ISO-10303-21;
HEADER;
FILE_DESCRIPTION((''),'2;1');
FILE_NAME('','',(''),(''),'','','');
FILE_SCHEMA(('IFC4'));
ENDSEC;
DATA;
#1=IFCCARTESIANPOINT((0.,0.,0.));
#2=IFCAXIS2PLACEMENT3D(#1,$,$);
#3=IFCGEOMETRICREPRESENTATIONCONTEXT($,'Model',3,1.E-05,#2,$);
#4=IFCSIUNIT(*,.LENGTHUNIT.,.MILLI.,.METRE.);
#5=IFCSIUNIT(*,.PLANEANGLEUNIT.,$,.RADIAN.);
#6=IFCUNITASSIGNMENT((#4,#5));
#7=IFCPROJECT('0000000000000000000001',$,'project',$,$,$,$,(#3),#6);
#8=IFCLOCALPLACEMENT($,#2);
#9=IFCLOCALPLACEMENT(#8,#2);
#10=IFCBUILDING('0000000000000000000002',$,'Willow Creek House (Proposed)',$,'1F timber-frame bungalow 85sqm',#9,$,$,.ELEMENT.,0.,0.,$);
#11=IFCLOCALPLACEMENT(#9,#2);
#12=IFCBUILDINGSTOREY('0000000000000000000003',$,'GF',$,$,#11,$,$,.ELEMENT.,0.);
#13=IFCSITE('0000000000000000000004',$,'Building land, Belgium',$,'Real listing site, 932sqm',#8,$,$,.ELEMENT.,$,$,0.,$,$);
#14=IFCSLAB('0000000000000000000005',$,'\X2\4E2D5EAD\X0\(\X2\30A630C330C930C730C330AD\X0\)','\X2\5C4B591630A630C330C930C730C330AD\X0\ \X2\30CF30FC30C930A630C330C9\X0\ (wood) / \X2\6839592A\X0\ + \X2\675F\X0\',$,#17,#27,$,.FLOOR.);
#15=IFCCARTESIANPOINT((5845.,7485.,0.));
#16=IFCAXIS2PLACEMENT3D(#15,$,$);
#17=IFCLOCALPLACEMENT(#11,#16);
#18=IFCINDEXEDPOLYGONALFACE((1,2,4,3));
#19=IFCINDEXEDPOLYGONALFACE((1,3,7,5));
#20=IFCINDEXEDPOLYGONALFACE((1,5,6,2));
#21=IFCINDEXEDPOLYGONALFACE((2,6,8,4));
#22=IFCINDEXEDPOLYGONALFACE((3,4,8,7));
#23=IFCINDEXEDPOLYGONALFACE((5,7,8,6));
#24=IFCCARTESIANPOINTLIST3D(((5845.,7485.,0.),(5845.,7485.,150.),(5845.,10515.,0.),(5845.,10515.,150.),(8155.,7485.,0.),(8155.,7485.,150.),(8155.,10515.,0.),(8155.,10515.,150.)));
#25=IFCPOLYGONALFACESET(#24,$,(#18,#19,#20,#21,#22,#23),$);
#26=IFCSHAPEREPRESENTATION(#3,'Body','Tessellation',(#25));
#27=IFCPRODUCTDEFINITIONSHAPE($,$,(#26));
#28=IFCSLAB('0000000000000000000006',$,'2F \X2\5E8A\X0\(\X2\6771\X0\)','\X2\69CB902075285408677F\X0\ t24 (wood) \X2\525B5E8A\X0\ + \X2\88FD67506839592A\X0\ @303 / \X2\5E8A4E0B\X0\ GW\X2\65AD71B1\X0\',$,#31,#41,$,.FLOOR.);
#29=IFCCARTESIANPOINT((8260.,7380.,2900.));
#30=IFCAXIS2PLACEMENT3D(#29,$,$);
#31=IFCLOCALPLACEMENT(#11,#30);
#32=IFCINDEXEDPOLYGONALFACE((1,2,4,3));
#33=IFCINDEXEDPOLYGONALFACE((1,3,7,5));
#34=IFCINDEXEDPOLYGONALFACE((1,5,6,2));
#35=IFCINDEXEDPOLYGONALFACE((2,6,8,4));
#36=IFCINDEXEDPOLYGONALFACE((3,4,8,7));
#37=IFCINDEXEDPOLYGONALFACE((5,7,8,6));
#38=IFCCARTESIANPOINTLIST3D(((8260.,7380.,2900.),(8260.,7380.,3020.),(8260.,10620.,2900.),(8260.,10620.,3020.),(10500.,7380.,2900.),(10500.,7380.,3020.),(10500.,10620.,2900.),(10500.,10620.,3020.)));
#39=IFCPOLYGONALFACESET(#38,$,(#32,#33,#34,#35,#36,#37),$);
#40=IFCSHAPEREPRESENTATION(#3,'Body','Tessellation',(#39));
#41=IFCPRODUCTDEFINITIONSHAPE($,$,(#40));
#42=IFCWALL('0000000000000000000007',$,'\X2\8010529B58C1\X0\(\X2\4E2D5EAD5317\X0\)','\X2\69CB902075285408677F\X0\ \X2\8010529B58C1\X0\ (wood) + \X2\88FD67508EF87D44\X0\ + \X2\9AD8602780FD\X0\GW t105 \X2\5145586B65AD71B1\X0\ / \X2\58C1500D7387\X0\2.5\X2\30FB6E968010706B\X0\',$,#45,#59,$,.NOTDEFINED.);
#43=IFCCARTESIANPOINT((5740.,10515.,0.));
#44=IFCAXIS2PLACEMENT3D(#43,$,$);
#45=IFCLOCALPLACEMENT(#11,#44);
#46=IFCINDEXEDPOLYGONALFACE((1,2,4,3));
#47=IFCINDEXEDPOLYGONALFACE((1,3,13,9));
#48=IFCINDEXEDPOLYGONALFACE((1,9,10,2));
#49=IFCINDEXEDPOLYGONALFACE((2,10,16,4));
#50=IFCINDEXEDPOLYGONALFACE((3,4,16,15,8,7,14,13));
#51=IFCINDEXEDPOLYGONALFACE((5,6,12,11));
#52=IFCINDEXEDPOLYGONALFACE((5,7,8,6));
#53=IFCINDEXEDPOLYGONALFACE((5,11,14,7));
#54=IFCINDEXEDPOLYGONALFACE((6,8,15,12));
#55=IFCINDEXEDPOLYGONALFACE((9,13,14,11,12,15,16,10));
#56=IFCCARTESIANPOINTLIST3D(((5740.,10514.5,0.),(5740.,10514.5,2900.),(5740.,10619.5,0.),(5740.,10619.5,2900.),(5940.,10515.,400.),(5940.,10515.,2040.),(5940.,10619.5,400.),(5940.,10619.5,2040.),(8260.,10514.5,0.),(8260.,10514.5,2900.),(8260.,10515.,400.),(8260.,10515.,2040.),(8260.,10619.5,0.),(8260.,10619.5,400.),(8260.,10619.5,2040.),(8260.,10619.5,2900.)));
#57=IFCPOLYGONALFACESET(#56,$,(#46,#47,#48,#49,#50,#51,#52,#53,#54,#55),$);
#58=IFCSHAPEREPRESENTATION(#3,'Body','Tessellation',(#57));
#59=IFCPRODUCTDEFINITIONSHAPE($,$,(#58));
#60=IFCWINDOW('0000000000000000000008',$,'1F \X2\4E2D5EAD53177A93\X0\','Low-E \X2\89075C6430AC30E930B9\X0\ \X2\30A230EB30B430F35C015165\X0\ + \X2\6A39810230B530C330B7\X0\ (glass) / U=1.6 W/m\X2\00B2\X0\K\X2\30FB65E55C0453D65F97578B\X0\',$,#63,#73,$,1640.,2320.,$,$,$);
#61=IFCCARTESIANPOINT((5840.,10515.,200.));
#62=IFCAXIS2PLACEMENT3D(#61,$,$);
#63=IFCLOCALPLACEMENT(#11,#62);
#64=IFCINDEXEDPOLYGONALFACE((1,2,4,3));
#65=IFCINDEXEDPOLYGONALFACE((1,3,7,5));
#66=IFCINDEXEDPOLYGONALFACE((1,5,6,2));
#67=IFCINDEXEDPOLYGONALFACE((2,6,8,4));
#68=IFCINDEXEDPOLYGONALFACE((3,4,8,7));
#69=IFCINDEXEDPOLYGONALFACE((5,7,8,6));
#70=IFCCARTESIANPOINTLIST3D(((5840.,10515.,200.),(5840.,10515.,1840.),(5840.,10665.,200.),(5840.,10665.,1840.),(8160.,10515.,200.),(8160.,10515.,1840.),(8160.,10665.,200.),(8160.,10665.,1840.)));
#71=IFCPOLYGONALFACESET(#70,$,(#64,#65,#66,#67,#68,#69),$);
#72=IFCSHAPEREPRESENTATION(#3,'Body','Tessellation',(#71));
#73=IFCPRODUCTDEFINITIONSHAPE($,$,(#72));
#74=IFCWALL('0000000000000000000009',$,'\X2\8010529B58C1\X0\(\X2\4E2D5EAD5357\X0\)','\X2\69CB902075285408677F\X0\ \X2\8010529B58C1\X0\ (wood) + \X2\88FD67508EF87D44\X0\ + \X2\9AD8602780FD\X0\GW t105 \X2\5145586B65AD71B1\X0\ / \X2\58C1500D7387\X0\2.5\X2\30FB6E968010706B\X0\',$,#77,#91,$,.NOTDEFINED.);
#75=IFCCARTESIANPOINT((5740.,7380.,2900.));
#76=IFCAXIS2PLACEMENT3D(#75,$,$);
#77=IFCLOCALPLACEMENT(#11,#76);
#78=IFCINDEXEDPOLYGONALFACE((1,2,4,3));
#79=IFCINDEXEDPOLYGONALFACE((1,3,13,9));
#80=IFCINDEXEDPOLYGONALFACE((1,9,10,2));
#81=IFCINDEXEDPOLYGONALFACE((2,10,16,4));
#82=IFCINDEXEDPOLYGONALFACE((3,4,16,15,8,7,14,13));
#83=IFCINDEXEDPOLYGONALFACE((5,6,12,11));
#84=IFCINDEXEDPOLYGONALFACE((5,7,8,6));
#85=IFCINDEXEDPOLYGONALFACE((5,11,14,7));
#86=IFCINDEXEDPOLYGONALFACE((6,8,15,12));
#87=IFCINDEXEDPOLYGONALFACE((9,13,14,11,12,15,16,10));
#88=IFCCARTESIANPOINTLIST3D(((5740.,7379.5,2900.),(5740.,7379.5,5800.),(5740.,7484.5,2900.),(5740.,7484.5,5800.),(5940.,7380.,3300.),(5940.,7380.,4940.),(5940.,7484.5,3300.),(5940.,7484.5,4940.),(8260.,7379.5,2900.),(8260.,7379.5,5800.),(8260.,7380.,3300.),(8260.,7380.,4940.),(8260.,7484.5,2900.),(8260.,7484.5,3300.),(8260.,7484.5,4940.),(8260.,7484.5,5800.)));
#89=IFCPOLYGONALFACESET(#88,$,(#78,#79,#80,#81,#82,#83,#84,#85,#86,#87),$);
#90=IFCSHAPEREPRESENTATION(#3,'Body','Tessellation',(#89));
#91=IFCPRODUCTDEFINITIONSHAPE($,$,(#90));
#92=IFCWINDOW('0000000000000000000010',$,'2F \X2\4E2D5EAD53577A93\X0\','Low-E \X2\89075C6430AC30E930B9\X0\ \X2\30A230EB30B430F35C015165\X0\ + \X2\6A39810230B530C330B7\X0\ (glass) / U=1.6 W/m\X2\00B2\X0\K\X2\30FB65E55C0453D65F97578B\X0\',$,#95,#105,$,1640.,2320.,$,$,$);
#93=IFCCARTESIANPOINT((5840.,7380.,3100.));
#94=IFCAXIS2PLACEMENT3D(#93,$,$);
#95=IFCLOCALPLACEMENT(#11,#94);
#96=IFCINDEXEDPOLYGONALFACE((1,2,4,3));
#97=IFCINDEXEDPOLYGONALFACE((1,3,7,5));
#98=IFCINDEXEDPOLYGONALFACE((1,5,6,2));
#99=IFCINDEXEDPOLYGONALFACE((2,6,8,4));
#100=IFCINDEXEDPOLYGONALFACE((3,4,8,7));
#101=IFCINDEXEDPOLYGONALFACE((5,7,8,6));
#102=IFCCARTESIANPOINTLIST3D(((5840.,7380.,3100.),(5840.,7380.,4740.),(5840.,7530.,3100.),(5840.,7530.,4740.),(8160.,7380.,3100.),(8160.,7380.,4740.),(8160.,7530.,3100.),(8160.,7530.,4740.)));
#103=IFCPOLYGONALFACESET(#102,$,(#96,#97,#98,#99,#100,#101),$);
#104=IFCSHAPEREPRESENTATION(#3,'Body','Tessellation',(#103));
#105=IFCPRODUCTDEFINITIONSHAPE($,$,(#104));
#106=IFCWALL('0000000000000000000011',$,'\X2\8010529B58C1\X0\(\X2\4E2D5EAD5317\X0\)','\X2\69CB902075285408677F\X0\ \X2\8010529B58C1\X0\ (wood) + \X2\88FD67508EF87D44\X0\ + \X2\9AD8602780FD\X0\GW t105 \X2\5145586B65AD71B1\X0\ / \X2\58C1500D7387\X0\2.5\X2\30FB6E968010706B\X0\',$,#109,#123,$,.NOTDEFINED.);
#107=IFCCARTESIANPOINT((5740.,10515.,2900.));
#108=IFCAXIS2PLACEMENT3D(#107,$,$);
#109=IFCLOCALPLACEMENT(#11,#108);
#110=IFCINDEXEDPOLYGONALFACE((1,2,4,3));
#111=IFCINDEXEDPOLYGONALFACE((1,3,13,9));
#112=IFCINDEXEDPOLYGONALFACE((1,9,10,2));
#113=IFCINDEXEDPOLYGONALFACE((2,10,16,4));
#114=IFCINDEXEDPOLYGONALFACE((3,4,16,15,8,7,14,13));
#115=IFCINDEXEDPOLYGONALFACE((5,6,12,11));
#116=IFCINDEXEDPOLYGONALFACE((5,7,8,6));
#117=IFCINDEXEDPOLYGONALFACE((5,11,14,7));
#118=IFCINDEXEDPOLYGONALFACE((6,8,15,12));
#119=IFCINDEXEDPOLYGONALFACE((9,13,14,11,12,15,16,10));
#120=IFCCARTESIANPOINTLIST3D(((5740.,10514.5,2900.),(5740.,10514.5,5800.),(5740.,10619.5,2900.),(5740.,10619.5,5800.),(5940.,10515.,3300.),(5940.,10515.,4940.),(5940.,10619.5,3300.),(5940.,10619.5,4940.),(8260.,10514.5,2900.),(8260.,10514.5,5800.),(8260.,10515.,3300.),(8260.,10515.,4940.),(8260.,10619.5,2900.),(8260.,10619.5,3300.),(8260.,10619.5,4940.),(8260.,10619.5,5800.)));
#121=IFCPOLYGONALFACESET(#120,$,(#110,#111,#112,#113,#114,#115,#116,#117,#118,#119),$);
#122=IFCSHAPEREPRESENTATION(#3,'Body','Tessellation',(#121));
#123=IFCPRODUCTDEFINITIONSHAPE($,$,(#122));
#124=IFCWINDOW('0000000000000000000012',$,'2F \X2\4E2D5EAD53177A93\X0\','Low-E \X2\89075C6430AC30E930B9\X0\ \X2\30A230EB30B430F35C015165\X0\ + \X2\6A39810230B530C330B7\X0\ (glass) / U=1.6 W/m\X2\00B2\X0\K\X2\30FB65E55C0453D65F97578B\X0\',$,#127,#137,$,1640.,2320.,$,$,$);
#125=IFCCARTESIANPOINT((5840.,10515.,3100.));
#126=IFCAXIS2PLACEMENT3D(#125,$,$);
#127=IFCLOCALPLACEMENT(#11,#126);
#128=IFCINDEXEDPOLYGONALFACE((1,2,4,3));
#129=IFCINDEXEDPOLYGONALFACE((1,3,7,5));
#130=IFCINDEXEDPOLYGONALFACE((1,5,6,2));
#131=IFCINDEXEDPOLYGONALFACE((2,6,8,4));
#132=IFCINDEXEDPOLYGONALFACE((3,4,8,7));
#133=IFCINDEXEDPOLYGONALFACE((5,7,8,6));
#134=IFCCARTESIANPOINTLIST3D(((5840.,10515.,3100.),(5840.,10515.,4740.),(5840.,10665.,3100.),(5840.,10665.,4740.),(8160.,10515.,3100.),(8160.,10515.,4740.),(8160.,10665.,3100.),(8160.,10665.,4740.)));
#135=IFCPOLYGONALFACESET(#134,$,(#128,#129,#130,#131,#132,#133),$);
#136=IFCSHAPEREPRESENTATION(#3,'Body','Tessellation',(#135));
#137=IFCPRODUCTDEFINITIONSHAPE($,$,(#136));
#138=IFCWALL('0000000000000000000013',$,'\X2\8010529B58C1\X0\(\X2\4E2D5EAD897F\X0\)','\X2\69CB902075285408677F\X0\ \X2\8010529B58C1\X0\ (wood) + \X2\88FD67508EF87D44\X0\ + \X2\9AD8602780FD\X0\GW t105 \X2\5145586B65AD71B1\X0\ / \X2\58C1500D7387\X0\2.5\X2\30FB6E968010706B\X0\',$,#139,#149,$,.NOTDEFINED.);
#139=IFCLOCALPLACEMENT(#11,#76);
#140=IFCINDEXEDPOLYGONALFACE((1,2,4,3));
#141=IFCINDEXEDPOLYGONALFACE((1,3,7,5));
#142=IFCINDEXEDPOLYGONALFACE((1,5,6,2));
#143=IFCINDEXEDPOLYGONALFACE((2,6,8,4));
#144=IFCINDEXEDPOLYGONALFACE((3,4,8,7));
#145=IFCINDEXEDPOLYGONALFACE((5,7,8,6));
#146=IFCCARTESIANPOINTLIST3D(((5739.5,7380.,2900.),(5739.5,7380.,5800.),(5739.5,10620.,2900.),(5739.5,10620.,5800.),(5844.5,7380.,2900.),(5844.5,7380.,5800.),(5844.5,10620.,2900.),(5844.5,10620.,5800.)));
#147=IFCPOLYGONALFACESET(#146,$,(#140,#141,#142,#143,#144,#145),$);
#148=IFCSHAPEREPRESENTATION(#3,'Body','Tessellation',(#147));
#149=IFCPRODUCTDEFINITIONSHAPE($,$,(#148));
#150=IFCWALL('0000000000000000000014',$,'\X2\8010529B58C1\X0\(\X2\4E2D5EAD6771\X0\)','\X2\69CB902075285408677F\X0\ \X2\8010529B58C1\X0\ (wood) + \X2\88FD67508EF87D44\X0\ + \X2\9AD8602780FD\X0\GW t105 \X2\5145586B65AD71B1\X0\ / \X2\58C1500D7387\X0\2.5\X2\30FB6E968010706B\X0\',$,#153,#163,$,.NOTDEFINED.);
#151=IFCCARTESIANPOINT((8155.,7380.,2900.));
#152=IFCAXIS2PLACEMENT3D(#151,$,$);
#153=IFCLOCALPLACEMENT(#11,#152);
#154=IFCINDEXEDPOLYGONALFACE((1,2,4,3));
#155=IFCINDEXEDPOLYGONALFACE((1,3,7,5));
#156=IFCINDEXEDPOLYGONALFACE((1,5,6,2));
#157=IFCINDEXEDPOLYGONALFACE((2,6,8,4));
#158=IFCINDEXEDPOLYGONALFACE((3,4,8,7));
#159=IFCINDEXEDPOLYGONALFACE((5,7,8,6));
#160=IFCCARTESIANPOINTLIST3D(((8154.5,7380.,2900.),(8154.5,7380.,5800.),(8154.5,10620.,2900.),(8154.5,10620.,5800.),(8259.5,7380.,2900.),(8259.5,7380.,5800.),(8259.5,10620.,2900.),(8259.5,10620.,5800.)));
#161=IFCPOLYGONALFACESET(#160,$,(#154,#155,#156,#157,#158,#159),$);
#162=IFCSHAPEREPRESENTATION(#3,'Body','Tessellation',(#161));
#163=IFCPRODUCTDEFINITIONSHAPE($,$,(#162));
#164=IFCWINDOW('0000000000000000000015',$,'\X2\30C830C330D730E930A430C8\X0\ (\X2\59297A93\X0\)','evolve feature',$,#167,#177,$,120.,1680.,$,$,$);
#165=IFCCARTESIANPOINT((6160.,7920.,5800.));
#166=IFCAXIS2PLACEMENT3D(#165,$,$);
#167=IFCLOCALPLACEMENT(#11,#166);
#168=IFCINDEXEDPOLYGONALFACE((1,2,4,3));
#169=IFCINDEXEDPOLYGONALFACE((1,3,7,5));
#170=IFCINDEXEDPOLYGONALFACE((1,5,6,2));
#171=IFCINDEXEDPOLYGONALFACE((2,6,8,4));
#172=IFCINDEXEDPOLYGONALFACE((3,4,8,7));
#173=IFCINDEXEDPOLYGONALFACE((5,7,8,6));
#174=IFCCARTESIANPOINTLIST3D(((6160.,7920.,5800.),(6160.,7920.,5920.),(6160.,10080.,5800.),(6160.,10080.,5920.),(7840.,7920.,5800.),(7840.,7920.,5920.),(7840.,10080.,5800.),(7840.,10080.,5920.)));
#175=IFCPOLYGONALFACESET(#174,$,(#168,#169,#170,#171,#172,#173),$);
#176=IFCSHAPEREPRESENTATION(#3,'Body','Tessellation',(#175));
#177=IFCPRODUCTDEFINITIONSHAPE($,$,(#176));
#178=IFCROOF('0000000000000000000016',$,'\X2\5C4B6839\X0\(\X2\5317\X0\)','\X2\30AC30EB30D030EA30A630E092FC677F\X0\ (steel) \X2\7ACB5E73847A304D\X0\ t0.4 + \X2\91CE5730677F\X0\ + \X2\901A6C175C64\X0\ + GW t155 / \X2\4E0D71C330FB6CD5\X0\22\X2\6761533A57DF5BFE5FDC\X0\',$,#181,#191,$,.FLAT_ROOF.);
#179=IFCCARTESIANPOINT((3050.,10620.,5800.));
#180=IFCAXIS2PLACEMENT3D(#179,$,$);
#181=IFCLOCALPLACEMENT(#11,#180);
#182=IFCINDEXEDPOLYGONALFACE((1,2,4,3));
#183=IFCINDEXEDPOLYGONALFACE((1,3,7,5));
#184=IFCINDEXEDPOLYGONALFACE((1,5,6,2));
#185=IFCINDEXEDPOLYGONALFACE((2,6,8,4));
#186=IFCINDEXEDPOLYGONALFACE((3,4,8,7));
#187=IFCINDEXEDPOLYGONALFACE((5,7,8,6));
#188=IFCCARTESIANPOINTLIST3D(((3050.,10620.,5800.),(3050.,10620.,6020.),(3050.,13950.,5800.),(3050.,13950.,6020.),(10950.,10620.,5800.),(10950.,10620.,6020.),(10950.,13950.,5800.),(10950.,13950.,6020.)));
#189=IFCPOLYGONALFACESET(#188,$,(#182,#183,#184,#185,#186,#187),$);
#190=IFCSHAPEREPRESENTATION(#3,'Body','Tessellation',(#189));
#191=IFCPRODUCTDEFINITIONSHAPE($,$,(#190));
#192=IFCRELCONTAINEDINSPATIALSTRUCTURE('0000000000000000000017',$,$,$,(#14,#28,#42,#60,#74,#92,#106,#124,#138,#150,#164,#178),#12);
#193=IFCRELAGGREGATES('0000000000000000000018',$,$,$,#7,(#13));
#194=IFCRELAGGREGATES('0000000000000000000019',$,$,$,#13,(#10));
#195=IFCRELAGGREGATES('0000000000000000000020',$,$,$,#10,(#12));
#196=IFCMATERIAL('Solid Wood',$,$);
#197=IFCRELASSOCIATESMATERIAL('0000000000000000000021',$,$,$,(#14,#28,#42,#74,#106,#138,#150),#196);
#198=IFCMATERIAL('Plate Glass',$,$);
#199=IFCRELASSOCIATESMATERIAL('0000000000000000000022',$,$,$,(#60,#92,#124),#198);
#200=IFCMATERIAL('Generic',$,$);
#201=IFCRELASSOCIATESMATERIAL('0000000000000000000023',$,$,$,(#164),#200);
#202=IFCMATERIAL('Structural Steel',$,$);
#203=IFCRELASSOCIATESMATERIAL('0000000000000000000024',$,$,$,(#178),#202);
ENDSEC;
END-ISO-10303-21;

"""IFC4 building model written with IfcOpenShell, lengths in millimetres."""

from ifc_helpers import new_model, si_unit, frame, frame_2d, origin, place, context, project, spatial, rectangle, extrude, material, element, fill, save


model = new_model("IFC4")

# Units and contexts
model_context = context("Model", 3, precision=1e-05, world=origin())
ifc_project = project(units=[si_unit("LENGTHUNIT", "METRE", prefix="MILLI"), si_unit("PLANEANGLEUNIT", "RADIAN")], contexts=[model_context])

# Site, building, storey
site_placement = place(None, origin())
site = spatial("IfcSite", under=ifc_project, at=site_placement, Name="Building land, Belgium", ObjectType="Real listing site, 932sqm", CompositionType="ELEMENT", RefElevation=0.0)
building_placement = place(site_placement, origin())
building = spatial("IfcBuilding", under=site, at=building_placement, Name="Willow Creek House (Proposed)", ObjectType="1F timber-frame bungalow 85sqm", CompositionType="ELEMENT", ElevationOfRefHeight=0.0, ElevationOfTerrain=0.0)
storey_placement = place(building_placement, origin())
storey = spatial("IfcBuildingStorey", under=building, at=storey_placement, Name="GF", CompositionType="ELEMENT", Elevation=0.0)

# Slabs
ifc_material_1 = material(Name="Solid Wood")
slab_1_placement = place(storey_placement, frame((5845.0, 7485.0, 0.0)))
element("IfcSlab", 1, at=slab_1_placement, inside=storey, material=ifc_material_1, Name="中庭(ウッドデッキ)", Description="屋外ウッドデッキ ハードウッド (wood) / 根太 + 束", PredefinedType="FLOOR", context=model_context, shape_type="SweptSolid", body=[
    extrude(rectangle(XDim=2310.0, YDim=3030.0, at=frame_2d((1155.0, 1515.0))), frame((5845.0, 7485.0, 0.0)), (0.0, 0.0, 1.0), 150.0),
])
slab_2_placement = place(storey_placement, frame((8260.0, 7380.0, 2900.0)))
element("IfcSlab", 2, at=slab_2_placement, inside=storey, material=ifc_material_1, Name="2F 床(東)", Description="構造用合板 t24 (wood) 剛床 + 製材根太 @303 / 床下 GW断熱", PredefinedType="FLOOR", context=model_context, shape_type="SweptSolid", body=[
    extrude(rectangle(XDim=2240.0, YDim=3240.0, at=frame_2d((1120.0, 1620.0))), frame((8260.0, 7380.0, 2900.0)), (0.0, 0.0, 1.0), 120.0),
])

# Walls, openings, windows
wall_1_placement = place(storey_placement, frame((5740.0, 10515.0, 0.0)))
wall_1 = element("IfcWall", 3, at=wall_1_placement, inside=storey, material=ifc_material_1, Name="耐力壁(中庭北)", Description="構造用合板 耐力壁 (wood) + 製材軸組 + 高性能GW t105 充填断熱 / 壁倍率2.5・準耐火", PredefinedType="NOTDEFINED", context=model_context, shape_type="SweptSolid", body=[
    extrude(rectangle(XDim=2520.0, YDim=105.0, at=frame_2d((1260.0, 52.0))), frame((5740.0, 10515.0, 0.0)), (0.0, 0.0, 1.0), 2900.0),
])
opening_1_placement = place(storey_placement, frame((5840.0, 10515.0, 200.0)))
opening_1 = element("IfcOpeningElement", 4, at=opening_1_placement, cuts=wall_1, PredefinedType="NOTDEFINED", context=model_context, shape_type="SweptSolid", body=[
    extrude(rectangle(XDim=2320.0, YDim=150.0, at=frame_2d((1160.0, 75.0))), frame((5840.0, 10515.0, 200.0)), (0.0, 0.0, 1.0), 1640.0),
])
ifc_material_2 = material(Name="Plate Glass")
window_1_placement = place(storey_placement, frame((5840.0, 10515.0, 200.0)))
window_1 = element("IfcWindow", 5, at=window_1_placement, inside=storey, material=ifc_material_2, Name="1F 中庭北窓", Description="Low-E 複層ガラス アルゴン封入 + 樹脂サッシ (glass) / U=1.6 W/m²K・日射取得型", OverallHeight=1640.0, OverallWidth=2320.0, context=model_context, shape_type="SweptSolid", body=[
    extrude(rectangle(XDim=2320.0, YDim=150.0, at=frame_2d((1160.0, 75.0))), frame((5840.0, 10515.0, 200.0)), (0.0, 0.0, 1.0), 1640.0),
])
fill(opening_1, window_1)
wall_2_placement = place(storey_placement, frame((5740.0, 7380.0, 2900.0)))
wall_2 = element("IfcWall", 6, at=wall_2_placement, inside=storey, material=ifc_material_1, Name="耐力壁(中庭南)", Description="構造用合板 耐力壁 (wood) + 製材軸組 + 高性能GW t105 充填断熱 / 壁倍率2.5・準耐火", PredefinedType="NOTDEFINED", context=model_context, shape_type="SweptSolid", body=[
    extrude(rectangle(XDim=2520.0, YDim=105.0, at=frame_2d((1260.0, 52.0))), frame((5740.0, 7380.0, 2900.0)), (0.0, 0.0, 1.0), 2900.0),
])
opening_2_placement = place(storey_placement, frame((5840.0, 7380.0, 3100.0)))
opening_2 = element("IfcOpeningElement", 7, at=opening_2_placement, cuts=wall_2, PredefinedType="NOTDEFINED", context=model_context, shape_type="SweptSolid", body=[
    extrude(rectangle(XDim=2320.0, YDim=150.0, at=frame_2d((1160.0, 75.0))), frame((5840.0, 7380.0, 3100.0)), (0.0, 0.0, 1.0), 1640.0),
])
window_2_placement = place(storey_placement, frame((5840.0, 7380.0, 3100.0)))
window_2 = element("IfcWindow", 8, at=window_2_placement, inside=storey, material=ifc_material_2, Name="2F 中庭南窓", Description="Low-E 複層ガラス アルゴン封入 + 樹脂サッシ (glass) / U=1.6 W/m²K・日射取得型", OverallHeight=1640.0, OverallWidth=2320.0, context=model_context, shape_type="SweptSolid", body=[
    extrude(rectangle(XDim=2320.0, YDim=150.0, at=frame_2d((1160.0, 75.0))), frame((5840.0, 7380.0, 3100.0)), (0.0, 0.0, 1.0), 1640.0),
])
fill(opening_2, window_2)
wall_3_placement = place(storey_placement, frame((5740.0, 10515.0, 2900.0)))
wall_3 = element("IfcWall", 9, at=wall_3_placement, inside=storey, material=ifc_material_1, Name="耐力壁(中庭北)", Description="構造用合板 耐力壁 (wood) + 製材軸組 + 高性能GW t105 充填断熱 / 壁倍率2.5・準耐火", PredefinedType="NOTDEFINED", context=model_context, shape_type="SweptSolid", body=[
    extrude(rectangle(XDim=2520.0, YDim=105.0, at=frame_2d((1260.0, 52.0))), frame((5740.0, 10515.0, 2900.0)), (0.0, 0.0, 1.0), 2900.0),
])
opening_3_placement = place(storey_placement, frame((5840.0, 10515.0, 3100.0)))
opening_3 = element("IfcOpeningElement", 10, at=opening_3_placement, cuts=wall_3, PredefinedType="NOTDEFINED", context=model_context, shape_type="SweptSolid", body=[
    extrude(rectangle(XDim=2320.0, YDim=150.0, at=frame_2d((1160.0, 75.0))), frame((5840.0, 10515.0, 3100.0)), (0.0, 0.0, 1.0), 1640.0),
])
window_3_placement = place(storey_placement, frame((5840.0, 10515.0, 3100.0)))
window_3 = element("IfcWindow", 11, at=window_3_placement, inside=storey, material=ifc_material_2, Name="2F 中庭北窓", Description="Low-E 複層ガラス アルゴン封入 + 樹脂サッシ (glass) / U=1.6 W/m²K・日射取得型", OverallHeight=1640.0, OverallWidth=2320.0, context=model_context, shape_type="SweptSolid", body=[
    extrude(rectangle(XDim=2320.0, YDim=150.0, at=frame_2d((1160.0, 75.0))), frame((5840.0, 10515.0, 3100.0)), (0.0, 0.0, 1.0), 1640.0),
])
fill(opening_3, window_3)

# Walls
wall_4_placement = place(storey_placement, frame((5740.0, 7380.0, 2900.0)))
element("IfcWall", 12, at=wall_4_placement, inside=storey, material=ifc_material_1, Name="耐力壁(中庭西)", Description="構造用合板 耐力壁 (wood) + 製材軸組 + 高性能GW t105 充填断熱 / 壁倍率2.5・準耐火", PredefinedType="NOTDEFINED", context=model_context, shape_type="SweptSolid", body=[
    extrude(rectangle(XDim=105.0, YDim=3240.0, at=frame_2d((52.0, 1620.0))), frame((5740.0, 7380.0, 2900.0)), (0.0, 0.0, 1.0), 2900.0),
])
wall_5_placement = place(storey_placement, frame((8155.0, 7380.0, 2900.0)))
element("IfcWall", 13, at=wall_5_placement, inside=storey, material=ifc_material_1, Name="耐力壁(中庭東)", Description="構造用合板 耐力壁 (wood) + 製材軸組 + 高性能GW t105 充填断熱 / 壁倍率2.5・準耐火", PredefinedType="NOTDEFINED", context=model_context, shape_type="SweptSolid", body=[
    extrude(rectangle(XDim=105.0, YDim=3240.0, at=frame_2d((52.0, 1620.0))), frame((8155.0, 7380.0, 2900.0)), (0.0, 0.0, 1.0), 2900.0),
])

# Window
ifc_material_3 = material(Name="Generic")
window_4_placement = place(storey_placement, frame((6160.0, 7920.0, 5800.0)))
element("IfcWindow", 14, at=window_4_placement, inside=storey, material=ifc_material_3, Name="トップライト (天窓)", Description="evolve feature", OverallHeight=120.0, OverallWidth=1680.0, context=model_context, shape_type="SweptSolid", body=[
    extrude(rectangle(XDim=1680.0, YDim=2160.0, at=frame_2d((840.0, 1080.0))), frame((6160.0, 7920.0, 5800.0)), (0.0, 0.0, 1.0), 120.0),
])

# Roof
ifc_material_4 = material(Name="Structural Steel")
roof_1_placement = place(storey_placement, frame((3050.0, 10620.0, 5800.0)))
element("IfcRoof", 15, at=roof_1_placement, inside=storey, material=ifc_material_4, Name="屋根(北)", Description="ガルバリウム鋼板 (steel) 立平葺き t0.4 + 野地板 + 通気層 + GW t155 / 不燃・法22条区域対応", PredefinedType="FLAT_ROOF", context=model_context, shape_type="SweptSolid", body=[
    extrude(rectangle(XDim=7900.0, YDim=3330.0, at=frame_2d((3950.0, 1665.0))), frame((3050.0, 10620.0, 5800.0)), (0.0, 0.0, 1.0), 220.0),
])

save(model, "model.ifc")
